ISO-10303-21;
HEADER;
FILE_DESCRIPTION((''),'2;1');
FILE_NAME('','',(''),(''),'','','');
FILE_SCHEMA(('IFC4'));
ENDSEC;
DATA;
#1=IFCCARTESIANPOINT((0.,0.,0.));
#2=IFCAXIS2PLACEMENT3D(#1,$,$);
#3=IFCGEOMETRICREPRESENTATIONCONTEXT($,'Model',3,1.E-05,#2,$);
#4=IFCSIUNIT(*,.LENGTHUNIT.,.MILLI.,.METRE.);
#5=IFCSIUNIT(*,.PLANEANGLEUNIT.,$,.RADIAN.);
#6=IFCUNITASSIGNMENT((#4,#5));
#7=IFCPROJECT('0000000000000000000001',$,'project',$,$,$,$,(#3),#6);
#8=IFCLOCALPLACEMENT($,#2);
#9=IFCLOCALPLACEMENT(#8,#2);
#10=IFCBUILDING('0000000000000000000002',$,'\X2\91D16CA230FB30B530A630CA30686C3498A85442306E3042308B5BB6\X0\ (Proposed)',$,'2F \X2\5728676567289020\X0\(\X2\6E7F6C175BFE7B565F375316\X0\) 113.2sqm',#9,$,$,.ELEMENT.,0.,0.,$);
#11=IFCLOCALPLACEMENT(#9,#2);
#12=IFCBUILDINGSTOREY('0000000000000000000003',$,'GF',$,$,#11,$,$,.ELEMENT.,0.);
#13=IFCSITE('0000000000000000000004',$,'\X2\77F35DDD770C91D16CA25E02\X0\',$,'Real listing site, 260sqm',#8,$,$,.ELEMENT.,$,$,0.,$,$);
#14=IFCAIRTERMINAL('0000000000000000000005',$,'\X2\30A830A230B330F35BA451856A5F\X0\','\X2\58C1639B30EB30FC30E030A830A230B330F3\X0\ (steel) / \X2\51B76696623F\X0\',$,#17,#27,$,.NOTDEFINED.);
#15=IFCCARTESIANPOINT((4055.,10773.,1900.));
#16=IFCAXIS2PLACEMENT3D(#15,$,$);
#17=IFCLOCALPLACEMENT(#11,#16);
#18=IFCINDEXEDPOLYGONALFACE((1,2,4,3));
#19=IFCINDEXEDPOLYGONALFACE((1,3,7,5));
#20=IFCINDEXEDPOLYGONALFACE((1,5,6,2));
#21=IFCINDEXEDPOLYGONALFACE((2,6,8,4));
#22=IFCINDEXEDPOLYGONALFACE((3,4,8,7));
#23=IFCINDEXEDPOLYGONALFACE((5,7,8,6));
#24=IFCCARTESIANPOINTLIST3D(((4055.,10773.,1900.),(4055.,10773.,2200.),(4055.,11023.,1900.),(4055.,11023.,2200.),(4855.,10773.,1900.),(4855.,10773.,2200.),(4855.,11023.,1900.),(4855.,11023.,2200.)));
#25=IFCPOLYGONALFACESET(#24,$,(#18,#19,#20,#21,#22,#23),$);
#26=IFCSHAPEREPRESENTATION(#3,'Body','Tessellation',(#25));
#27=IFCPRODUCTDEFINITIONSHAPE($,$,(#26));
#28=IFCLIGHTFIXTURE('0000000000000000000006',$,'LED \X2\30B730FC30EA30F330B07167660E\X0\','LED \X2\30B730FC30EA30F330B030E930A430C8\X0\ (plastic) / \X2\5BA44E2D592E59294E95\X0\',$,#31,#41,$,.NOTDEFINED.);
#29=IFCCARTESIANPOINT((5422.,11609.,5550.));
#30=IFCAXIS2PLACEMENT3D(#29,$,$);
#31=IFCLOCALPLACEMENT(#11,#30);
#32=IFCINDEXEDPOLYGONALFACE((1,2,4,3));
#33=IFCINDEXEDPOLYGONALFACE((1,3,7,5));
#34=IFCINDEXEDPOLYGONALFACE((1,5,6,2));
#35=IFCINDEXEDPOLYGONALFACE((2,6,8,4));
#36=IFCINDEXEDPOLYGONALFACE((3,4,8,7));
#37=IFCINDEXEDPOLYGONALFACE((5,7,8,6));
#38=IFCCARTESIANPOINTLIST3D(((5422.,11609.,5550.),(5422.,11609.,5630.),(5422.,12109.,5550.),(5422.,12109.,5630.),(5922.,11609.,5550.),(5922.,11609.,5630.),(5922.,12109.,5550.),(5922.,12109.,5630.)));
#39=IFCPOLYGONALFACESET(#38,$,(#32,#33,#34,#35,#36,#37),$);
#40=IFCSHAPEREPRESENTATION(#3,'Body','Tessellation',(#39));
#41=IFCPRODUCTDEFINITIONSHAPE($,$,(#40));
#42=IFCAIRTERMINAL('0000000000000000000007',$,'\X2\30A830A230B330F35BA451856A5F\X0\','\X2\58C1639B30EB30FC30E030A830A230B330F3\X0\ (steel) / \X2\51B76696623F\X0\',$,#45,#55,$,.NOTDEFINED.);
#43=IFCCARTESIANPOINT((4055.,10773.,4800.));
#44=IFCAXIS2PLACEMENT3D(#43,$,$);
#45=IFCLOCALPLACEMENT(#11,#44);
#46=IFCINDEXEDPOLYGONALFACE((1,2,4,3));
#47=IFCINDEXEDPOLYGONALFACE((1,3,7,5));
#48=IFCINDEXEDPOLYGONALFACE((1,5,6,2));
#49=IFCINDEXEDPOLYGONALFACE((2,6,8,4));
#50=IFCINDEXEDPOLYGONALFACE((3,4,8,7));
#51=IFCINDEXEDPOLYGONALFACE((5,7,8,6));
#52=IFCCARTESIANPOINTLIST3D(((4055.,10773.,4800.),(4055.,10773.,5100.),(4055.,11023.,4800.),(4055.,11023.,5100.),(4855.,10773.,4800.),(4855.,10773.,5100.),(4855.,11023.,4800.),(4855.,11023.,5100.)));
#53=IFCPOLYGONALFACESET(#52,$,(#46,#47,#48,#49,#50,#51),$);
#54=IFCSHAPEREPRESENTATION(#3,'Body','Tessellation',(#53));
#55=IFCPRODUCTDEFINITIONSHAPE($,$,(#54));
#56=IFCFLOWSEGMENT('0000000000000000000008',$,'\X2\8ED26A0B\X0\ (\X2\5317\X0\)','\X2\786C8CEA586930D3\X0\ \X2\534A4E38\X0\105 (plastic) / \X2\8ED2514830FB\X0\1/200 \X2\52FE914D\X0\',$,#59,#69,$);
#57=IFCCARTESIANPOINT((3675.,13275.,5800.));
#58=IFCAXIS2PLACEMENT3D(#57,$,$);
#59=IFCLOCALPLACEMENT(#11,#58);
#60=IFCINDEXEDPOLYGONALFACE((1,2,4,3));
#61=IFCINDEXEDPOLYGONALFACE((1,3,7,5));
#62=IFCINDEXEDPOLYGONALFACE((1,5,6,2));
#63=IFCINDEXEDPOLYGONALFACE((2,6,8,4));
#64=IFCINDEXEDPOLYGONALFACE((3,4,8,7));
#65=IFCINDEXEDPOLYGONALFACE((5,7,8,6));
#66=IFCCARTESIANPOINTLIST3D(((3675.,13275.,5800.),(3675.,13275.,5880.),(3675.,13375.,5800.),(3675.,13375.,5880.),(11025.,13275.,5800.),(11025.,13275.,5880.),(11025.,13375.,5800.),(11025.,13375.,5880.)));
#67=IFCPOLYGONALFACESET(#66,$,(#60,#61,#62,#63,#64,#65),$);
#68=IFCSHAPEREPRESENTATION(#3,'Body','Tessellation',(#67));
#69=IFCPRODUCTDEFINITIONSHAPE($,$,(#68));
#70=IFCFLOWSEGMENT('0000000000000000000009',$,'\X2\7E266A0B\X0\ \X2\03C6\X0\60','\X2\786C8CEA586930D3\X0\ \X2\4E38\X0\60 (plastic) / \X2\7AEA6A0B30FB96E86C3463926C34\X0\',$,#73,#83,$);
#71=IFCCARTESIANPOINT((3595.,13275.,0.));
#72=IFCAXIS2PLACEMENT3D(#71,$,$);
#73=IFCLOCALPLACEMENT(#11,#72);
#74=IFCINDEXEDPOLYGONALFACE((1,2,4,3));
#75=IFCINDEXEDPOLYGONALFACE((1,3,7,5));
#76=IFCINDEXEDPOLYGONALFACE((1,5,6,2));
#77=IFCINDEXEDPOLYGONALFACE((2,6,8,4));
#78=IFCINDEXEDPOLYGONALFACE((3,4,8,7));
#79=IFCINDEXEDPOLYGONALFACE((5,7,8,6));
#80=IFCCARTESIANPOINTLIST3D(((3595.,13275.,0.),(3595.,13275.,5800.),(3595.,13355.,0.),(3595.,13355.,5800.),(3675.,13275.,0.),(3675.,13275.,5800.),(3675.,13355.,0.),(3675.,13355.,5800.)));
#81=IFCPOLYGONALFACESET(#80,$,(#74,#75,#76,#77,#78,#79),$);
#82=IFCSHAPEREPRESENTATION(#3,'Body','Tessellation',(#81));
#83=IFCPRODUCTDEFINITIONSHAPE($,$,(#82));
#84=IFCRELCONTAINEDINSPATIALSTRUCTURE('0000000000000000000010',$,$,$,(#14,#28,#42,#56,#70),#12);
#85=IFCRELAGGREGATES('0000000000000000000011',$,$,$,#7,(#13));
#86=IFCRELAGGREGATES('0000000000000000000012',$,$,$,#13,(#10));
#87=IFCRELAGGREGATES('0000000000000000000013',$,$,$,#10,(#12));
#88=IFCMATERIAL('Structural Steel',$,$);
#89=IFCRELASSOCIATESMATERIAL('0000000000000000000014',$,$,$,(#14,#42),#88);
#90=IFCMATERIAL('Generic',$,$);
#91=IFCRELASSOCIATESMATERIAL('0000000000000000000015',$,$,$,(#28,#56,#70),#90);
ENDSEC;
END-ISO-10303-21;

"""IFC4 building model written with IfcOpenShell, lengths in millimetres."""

from ifc_helpers import new_model, si_unit, frame, frame_2d, origin, place, context, project, spatial, rectangle, extrude, material, element, save


model = new_model("IFC4")

# Units and contexts
model_context = context("Model", 3, precision=1e-05, world=origin())
ifc_project = project(units=[si_unit("LENGTHUNIT", "METRE", prefix="MILLI"), si_unit("PLANEANGLEUNIT", "RADIAN")], contexts=[model_context])

# Site, building, storey
site_placement = place(None, origin())
site = spatial("IfcSite", under=ifc_project, at=site_placement, Name="石川県金沢市", ObjectType="Real listing site, 260sqm", CompositionType="ELEMENT", RefElevation=0.0)
building_placement = place(site_placement, origin())
building = spatial("IfcBuilding", under=site, at=building_placement, Name="金沢・サウナと水風呂のある家 (Proposed)", ObjectType="2F 在来木造(湿気対策強化) 113.2sqm", CompositionType="ELEMENT", ElevationOfRefHeight=0.0, ElevationOfTerrain=0.0)
storey_placement = place(building_placement, origin())
storey = spatial("IfcBuildingStorey", under=building, at=storey_placement, Name="GF", CompositionType="ELEMENT", Elevation=0.0)

# Shared definitions
ifc_material_1 = material(Name="Generic")

# Shared definitions
ifc_material_2 = material(Name="Structural Steel")

# Air terminal
air_terminal_1_placement = place(storey_placement, frame((4055.0, 10773.0, 1900.0)))
element("IfcAirTerminal", 1, at=air_terminal_1_placement, inside=storey, material=ifc_material_2, Name="エアコン室内機", Description="壁掛ルームエアコン (steel) / 冷暖房", PredefinedType="NOTDEFINED", context=model_context, shape_type="SweptSolid", body=[
    extrude(rectangle(XDim=800.0, YDim=250.0, at=frame_2d((400.0, 125.0))), frame((4055.0, 10773.0, 1900.0)), (0.0, 0.0, 1.0), 300.0),
])

# Light fixture
light_fixture_placement = place(storey_placement, frame((5422.0, 11609.0, 5550.0)))
element("IfcLightFixture", 2, at=light_fixture_placement, inside=storey, material=ifc_material_1, Name="LED シーリング照明", Description="LED シーリングライト (plastic) / 室中央天井", PredefinedType="NOTDEFINED", context=model_context, shape_type="SweptSolid", body=[
    extrude(rectangle(XDim=500.0, YDim=500.0, at=frame_2d((250.0, 250.0))), frame((5422.0, 11609.0, 5550.0)), (0.0, 0.0, 1.0), 80.0),
])

# Air terminal
air_terminal_2_placement = place(storey_placement, frame((4055.0, 10773.0, 4800.0)))
element("IfcAirTerminal", 3, at=air_terminal_2_placement, inside=storey, material=ifc_material_2, Name="エアコン室内機", Description="壁掛ルームエアコン (steel) / 冷暖房", PredefinedType="NOTDEFINED", context=model_context, shape_type="SweptSolid", body=[
    extrude(rectangle(XDim=800.0, YDim=250.0, at=frame_2d((400.0, 125.0))), frame((4055.0, 10773.0, 4800.0)), (0.0, 0.0, 1.0), 300.0),
])

# Flow segments
flow_segment_1_placement = place(storey_placement, frame((3675.0, 13275.0, 5800.0)))
element("IfcFlowSegment", 4, at=flow_segment_1_placement, inside=storey, material=ifc_material_1, Name="軒樋 (北)", Description="硬質塩ビ 半丸105 (plastic) / 軒先・1/200 勾配", context=model_context, shape_type="SweptSolid", body=[
    extrude(rectangle(XDim=7350.0, YDim=100.0, at=frame_2d((3675.0, 50.0))), frame((3675.0, 13275.0, 5800.0)), (0.0, 0.0, 1.0), 80.0),
])
flow_segment_2_placement = place(storey_placement, frame((3595.0, 13275.0, 0.0)))
element("IfcFlowSegment", 5, at=flow_segment_2_placement, inside=storey, material=ifc_material_1, Name="縦樋 φ60", Description="硬質塩ビ 丸60 (plastic) / 竪樋・雨水排水", context=model_context, shape_type="SweptSolid", body=[
    extrude(rectangle(XDim=80.0, YDim=80.0, at=frame_2d((40.0, 40.0))), frame((3595.0, 13275.0, 0.0)), (0.0, 0.0, 1.0), 5800.0),
])

save(model, "model.ifc")
